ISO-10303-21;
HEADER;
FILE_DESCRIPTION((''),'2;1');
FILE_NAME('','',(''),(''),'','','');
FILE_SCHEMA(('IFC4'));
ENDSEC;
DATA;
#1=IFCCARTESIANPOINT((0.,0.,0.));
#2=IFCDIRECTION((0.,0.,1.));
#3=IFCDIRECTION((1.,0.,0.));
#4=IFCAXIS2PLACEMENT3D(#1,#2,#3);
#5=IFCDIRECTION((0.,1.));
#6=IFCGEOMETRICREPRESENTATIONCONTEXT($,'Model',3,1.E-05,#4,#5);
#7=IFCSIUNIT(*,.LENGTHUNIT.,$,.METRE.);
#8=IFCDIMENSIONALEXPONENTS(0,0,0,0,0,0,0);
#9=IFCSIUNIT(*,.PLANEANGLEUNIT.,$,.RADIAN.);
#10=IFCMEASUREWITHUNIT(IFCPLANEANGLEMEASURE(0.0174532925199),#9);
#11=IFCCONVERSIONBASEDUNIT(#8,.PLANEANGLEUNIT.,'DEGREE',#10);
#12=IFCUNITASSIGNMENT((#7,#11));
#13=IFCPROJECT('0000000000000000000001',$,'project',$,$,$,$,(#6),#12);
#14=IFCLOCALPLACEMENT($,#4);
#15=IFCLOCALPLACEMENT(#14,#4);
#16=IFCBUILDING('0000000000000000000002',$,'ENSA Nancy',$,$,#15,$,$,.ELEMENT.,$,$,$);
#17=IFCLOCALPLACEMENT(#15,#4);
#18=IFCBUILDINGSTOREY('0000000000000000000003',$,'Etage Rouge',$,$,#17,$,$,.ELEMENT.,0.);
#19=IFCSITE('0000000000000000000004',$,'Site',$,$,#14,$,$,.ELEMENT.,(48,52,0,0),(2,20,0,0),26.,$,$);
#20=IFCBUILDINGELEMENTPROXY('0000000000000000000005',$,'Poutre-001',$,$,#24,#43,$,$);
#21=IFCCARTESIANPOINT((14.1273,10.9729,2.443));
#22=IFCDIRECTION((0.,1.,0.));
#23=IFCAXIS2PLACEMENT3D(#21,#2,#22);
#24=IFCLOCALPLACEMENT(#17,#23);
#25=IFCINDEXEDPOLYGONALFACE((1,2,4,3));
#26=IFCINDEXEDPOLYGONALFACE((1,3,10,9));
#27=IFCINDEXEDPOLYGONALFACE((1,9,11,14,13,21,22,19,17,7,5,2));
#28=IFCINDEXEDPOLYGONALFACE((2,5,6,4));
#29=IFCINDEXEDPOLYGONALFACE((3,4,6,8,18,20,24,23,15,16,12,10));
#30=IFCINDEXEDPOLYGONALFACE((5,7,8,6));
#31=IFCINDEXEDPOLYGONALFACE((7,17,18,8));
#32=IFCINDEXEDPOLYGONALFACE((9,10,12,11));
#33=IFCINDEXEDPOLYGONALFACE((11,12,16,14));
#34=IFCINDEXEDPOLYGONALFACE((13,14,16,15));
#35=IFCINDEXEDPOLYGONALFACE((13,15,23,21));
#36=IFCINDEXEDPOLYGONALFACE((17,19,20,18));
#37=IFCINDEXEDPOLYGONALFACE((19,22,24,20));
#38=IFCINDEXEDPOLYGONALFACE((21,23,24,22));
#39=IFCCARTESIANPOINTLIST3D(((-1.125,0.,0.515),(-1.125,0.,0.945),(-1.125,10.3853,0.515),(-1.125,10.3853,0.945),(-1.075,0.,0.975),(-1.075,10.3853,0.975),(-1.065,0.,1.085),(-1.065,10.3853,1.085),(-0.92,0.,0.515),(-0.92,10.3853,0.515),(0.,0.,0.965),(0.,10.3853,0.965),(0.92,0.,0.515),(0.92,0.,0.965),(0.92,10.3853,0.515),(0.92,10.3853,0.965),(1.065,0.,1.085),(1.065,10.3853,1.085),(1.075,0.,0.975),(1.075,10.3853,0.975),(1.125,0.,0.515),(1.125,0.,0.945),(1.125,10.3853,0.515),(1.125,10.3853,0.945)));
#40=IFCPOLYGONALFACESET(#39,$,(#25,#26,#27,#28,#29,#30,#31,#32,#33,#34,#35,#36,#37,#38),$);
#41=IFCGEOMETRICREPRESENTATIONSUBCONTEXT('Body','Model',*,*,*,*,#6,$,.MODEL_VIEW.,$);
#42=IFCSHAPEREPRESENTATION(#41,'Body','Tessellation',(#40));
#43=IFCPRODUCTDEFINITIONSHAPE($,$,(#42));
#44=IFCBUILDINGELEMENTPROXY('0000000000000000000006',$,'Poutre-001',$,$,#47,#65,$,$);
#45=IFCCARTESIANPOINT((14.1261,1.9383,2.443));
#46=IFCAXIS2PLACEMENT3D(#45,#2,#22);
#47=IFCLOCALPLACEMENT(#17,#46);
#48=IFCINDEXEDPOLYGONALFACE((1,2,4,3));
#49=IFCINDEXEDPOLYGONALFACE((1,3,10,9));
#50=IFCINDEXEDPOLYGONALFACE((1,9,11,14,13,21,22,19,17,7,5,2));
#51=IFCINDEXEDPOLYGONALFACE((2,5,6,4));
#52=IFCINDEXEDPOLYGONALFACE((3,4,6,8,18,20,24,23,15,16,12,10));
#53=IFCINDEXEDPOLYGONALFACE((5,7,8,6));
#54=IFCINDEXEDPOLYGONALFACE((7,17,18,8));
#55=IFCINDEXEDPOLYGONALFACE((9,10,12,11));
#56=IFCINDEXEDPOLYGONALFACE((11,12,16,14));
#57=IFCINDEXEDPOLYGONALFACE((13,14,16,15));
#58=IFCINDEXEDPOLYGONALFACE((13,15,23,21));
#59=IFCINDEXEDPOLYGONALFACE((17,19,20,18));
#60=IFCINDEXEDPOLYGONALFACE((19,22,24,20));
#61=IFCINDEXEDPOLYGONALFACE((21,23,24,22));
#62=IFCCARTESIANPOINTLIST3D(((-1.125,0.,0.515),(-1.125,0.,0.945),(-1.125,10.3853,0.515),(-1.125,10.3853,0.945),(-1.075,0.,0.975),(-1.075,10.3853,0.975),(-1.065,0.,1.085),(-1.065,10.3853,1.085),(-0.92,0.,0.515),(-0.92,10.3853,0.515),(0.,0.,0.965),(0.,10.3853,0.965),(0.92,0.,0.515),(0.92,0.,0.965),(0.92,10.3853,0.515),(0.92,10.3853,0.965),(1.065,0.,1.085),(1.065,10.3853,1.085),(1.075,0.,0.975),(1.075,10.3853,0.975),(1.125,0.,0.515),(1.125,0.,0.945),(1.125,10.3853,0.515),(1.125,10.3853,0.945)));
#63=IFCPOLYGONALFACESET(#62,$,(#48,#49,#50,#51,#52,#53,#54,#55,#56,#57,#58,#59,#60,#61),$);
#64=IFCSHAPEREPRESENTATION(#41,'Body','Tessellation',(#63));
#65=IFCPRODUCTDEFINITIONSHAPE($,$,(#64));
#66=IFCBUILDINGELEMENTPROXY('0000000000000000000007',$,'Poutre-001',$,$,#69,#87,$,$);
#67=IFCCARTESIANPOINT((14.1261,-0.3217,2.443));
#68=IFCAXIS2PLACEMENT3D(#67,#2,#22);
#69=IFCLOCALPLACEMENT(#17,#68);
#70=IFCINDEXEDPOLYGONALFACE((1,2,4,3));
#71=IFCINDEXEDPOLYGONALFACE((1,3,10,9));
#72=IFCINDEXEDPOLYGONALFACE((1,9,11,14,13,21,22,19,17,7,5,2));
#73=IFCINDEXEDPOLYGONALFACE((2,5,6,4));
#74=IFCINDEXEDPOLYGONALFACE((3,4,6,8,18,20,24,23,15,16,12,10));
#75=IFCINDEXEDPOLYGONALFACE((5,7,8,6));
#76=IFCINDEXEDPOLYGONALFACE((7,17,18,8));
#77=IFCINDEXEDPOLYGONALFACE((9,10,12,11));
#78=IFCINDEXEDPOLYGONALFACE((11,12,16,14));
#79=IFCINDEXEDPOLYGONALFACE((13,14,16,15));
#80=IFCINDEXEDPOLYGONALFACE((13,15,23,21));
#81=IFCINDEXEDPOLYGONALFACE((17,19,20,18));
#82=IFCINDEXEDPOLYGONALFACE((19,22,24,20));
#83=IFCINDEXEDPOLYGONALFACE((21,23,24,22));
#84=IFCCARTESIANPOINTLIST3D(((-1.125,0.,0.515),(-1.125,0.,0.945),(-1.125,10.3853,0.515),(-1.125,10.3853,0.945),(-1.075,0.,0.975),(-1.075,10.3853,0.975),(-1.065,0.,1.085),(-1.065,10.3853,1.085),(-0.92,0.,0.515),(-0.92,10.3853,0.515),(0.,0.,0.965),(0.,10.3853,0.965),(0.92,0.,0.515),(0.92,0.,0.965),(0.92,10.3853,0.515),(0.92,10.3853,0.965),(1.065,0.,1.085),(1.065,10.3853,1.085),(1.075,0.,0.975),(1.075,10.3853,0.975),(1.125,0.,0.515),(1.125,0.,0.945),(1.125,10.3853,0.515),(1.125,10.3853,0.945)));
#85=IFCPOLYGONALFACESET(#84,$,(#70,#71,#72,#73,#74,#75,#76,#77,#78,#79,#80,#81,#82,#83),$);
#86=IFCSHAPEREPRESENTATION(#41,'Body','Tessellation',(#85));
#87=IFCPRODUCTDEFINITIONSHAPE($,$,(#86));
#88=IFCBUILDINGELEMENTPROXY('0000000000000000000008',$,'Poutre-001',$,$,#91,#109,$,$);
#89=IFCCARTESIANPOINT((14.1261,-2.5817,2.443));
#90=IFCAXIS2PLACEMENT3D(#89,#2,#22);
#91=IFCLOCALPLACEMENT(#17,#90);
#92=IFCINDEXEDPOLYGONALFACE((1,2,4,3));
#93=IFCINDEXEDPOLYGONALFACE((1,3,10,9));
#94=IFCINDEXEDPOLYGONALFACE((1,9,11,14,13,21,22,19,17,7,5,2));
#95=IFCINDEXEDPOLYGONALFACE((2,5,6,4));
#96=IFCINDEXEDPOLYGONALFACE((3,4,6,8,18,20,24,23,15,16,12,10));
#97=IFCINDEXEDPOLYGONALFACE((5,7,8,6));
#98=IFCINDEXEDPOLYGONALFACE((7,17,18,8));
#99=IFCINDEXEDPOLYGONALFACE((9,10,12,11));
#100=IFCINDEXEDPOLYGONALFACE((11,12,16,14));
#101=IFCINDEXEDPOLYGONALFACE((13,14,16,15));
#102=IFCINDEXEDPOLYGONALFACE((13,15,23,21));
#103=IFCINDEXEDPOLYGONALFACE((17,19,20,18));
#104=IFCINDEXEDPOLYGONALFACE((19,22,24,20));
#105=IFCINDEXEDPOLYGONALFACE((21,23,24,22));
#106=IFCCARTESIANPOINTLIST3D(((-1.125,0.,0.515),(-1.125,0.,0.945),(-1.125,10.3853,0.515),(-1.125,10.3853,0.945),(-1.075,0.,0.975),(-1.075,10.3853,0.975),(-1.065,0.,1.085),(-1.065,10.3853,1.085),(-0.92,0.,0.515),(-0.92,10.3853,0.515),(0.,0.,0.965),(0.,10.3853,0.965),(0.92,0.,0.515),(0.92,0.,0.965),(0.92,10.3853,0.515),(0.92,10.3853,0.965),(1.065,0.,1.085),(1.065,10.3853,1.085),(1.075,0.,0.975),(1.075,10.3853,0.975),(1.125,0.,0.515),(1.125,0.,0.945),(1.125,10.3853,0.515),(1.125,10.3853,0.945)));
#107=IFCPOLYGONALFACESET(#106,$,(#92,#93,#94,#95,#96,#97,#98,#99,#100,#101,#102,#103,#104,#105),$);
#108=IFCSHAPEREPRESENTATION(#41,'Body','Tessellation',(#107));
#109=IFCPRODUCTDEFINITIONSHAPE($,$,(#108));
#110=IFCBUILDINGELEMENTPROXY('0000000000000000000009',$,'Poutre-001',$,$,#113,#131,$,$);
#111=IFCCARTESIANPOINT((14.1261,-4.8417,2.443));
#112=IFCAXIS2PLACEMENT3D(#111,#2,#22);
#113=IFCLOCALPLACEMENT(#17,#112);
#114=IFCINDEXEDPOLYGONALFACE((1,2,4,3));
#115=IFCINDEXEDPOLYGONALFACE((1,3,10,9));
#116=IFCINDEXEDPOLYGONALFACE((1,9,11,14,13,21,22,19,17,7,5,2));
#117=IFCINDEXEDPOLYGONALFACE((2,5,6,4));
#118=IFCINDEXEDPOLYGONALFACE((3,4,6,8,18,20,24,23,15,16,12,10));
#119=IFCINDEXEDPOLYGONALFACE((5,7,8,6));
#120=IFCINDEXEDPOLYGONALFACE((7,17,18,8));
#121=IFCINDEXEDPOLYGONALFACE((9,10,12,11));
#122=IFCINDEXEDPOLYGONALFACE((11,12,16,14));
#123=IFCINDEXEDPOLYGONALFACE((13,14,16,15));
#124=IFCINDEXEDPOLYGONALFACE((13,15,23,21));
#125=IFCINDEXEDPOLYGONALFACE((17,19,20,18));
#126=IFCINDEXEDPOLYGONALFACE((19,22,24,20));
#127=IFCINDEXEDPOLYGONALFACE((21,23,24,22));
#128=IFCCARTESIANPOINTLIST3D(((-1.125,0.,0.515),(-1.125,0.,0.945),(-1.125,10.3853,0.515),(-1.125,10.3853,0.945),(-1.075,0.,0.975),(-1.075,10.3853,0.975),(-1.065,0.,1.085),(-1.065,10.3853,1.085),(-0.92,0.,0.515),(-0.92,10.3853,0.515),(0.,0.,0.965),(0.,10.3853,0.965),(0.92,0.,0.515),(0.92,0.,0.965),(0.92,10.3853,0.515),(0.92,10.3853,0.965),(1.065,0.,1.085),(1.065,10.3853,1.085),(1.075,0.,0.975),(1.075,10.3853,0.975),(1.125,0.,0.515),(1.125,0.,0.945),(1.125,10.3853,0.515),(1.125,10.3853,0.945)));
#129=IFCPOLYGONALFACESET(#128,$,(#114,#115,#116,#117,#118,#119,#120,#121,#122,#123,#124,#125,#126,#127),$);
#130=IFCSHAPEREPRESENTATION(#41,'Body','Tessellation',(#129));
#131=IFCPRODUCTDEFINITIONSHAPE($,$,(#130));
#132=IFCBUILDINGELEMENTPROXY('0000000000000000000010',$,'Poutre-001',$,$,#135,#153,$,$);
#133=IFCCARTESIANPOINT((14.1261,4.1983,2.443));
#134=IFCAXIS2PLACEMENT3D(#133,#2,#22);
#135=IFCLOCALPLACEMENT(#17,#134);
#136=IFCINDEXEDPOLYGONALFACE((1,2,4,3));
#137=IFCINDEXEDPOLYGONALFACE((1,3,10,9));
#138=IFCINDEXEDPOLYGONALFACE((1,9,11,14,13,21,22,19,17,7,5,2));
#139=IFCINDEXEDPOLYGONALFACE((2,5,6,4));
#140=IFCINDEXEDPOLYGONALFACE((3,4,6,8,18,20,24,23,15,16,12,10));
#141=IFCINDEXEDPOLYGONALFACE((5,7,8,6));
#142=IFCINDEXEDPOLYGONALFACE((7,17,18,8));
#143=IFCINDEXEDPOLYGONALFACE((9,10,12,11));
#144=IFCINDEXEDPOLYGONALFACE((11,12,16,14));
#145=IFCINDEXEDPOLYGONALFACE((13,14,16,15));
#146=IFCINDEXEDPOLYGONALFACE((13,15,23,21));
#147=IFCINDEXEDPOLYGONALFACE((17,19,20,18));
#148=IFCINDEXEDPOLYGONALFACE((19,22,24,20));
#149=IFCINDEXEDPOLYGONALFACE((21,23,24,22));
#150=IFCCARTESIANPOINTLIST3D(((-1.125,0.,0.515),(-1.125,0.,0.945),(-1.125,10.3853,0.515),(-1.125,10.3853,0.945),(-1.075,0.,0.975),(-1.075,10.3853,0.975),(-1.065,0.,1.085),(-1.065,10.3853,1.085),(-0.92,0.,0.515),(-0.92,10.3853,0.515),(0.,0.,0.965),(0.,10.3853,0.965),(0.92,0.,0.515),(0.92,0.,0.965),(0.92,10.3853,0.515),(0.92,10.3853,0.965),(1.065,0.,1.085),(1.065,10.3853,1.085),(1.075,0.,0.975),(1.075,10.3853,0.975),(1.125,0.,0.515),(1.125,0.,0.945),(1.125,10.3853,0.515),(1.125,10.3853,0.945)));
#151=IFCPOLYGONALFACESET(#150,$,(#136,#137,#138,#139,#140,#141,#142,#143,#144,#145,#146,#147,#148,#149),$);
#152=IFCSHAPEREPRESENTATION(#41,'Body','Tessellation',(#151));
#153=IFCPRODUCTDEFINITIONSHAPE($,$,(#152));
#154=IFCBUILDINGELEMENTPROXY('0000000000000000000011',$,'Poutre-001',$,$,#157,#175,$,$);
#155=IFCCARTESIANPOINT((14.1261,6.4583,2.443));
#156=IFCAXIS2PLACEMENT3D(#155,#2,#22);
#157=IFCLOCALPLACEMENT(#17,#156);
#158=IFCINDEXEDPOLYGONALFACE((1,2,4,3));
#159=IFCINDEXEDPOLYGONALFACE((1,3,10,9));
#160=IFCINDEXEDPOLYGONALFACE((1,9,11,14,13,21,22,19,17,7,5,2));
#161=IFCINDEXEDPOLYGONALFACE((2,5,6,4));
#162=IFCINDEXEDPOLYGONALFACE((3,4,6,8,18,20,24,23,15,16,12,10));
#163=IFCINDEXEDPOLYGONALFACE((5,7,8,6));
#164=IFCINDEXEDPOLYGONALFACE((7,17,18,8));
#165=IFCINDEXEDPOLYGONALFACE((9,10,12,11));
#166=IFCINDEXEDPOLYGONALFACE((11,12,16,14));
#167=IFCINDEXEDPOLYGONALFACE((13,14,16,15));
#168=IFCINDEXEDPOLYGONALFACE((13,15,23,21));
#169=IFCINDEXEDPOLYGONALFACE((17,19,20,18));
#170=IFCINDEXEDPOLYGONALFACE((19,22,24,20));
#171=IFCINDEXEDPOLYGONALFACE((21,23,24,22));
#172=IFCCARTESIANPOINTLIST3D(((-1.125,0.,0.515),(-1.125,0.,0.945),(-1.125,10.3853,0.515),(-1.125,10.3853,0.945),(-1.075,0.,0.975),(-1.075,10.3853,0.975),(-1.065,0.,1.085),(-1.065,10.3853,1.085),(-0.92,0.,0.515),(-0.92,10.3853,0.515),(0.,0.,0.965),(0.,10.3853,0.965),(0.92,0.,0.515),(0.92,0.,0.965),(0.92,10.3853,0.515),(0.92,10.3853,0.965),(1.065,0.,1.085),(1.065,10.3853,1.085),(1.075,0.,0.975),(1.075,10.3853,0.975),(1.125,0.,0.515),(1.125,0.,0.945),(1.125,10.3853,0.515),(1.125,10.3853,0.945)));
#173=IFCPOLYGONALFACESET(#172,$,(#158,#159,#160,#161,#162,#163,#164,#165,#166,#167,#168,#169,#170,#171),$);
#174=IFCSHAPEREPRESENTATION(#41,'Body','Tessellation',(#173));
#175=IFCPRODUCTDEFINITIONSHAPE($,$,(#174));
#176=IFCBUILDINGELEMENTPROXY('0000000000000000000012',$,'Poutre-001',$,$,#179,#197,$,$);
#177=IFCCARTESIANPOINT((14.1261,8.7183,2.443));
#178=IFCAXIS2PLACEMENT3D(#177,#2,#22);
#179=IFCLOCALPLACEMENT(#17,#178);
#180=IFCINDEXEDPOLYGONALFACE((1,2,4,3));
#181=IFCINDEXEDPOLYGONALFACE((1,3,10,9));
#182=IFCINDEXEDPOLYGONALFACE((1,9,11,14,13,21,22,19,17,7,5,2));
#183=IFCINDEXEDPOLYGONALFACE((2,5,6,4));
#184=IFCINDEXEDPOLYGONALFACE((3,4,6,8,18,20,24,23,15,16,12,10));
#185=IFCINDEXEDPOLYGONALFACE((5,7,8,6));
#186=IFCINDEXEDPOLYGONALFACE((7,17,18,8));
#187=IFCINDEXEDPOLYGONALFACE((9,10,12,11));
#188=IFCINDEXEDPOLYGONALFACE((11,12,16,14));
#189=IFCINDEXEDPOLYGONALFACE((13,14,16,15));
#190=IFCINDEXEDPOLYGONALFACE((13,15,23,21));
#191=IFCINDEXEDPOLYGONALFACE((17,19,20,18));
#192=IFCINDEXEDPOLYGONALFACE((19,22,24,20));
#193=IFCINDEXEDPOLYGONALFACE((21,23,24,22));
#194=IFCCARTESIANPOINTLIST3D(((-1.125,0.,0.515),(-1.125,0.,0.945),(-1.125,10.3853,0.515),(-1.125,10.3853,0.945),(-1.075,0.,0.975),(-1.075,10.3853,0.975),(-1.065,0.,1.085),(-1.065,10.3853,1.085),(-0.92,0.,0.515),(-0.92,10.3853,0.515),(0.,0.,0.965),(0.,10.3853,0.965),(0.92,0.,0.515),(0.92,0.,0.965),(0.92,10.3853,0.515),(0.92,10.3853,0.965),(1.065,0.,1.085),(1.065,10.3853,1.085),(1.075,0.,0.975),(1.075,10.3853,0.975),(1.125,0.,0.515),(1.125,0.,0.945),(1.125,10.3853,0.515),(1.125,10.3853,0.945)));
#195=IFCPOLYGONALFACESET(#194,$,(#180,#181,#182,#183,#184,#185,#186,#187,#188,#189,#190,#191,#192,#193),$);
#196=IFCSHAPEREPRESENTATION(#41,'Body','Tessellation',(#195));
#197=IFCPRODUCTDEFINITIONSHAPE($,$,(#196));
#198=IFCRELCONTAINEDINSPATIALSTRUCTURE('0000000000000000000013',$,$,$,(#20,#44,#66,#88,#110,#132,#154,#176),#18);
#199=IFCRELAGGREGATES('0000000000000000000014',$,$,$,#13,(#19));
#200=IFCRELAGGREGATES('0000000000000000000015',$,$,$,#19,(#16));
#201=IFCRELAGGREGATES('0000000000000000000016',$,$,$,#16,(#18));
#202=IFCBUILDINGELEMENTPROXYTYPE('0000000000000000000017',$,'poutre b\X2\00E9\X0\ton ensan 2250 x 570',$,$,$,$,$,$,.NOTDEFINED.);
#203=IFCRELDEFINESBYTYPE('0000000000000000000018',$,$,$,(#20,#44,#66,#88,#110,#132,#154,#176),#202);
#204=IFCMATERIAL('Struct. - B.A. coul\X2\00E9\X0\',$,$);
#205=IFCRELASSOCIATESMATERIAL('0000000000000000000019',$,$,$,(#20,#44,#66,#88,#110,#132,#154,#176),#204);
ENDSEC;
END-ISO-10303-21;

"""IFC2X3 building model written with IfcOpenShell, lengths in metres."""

from ifc_helpers import new_model, entity, si_unit, converted_unit, direction, frame, origin_with_axes, place, context, subcontext, project, spatial, polyline, outline, extrude, material, type_object, element, save


model = new_model("IFC2X3")

# Units and contexts
model_context = context("Model", 3, precision=1e-05, world=origin_with_axes(), true_north=direction((0.0, 1.0)))
body_context = subcontext(model_context, "Body", "Model", "MODEL_VIEW")
ifc_project = project(units=[si_unit("LENGTHUNIT", "METRE"), converted_unit("PLANEANGLEUNIT", "DEGREE", entity("IfcPlaneAngleMeasure", 0.0174532925199), si_unit("PLANEANGLEUNIT", "RADIAN"), dimensions=[0, 0, 0, 0, 0, 0, 0])], contexts=[model_context])

# Site, building, storey
site_placement = place(None, origin_with_axes())
site = spatial("IfcSite", under=ifc_project, at=site_placement, Name="Site", CompositionType="ELEMENT", RefLatitude=(48, 52, 0, 0), RefLongitude=(2, 20, 0, 0), RefElevation=26.0)
building_placement = place(site_placement, origin_with_axes())
building = spatial("IfcBuilding", under=site, at=building_placement, Name="ENSA Nancy", CompositionType="ELEMENT")
storey_placement = place(building_placement, origin_with_axes())
storey = spatial("IfcBuildingStorey", under=building, at=storey_placement, Name="Etage Rouge", CompositionType="ELEMENT", Elevation=0.0)

# Building element proxies
ifc_material_1 = material(Name="Struct. - B.A. coulé")
building_element_proxy_type_1 = type_object("IfcBuildingElementProxyType", Name="poutre béton ensan 2250 x 570", PredefinedType="NOTDEFINED")
for number, where, z_axis, x_axis, name in (
    (1, (14.1273, 10.9729, 2.443), (0.0, 0.0, 1.0), (0.0, 1.0, 0.0), "Poutre-001"),
    (2, (14.1261, 1.9383, 2.443), (0.0, 0.0, 1.0), (0.0, 1.0, 0.0), "Poutre-001"),
    (3, (14.1261, -0.3217, 2.443), (0.0, 0.0, 1.0), (0.0, 1.0, 0.0), "Poutre-001"),
    (4, (14.1261, -2.5817, 2.443), (0.0, 0.0, 1.0), (0.0, 1.0, 0.0), "Poutre-001"),
    (5, (14.1261, -4.8417, 2.443), (0.0, 0.0, 1.0), (0.0, 1.0, 0.0), "Poutre-001"),
    (6, (14.1261, 4.1983, 2.443), (0.0, 0.0, 1.0), (0.0, 1.0, 0.0), "Poutre-001"),
    (7, (14.1261, 6.4583, 2.443), (0.0, 0.0, 1.0), (0.0, 1.0, 0.0), "Poutre-001"),
    (8, (14.1261, 8.7183, 2.443), (0.0, 0.0, 1.0), (0.0, 1.0, 0.0), "Poutre-001"),
):
    element("IfcBuildingElementProxy", number, at=place(storey_placement, frame(where, z_axis=z_axis, x_axis=x_axis)), inside=storey, type_object=building_element_proxy_type_1, material=ifc_material_1, Name=name, context=body_context, shape_type="SweptSolid", body=[
        extrude(outline(polyline([(-1.065, 1.085), (-1.075, 0.975), (-1.125, 0.945), (-1.125, 0.515), (-0.92, 0.515), (0.0, 0.965), (0.92, 0.965), (0.92, 0.515), (1.125, 0.515), (1.125, 0.945), (1.075, 0.975), (1.065, 1.085), (-1.065, 1.085)])), frame((0.0, 10.3853, 0.0), z_axis=(0.0, -1.0, 0.0), x_axis=(1.0, 0.0, 0.0)), (0.0, 0.0, 1.0), 10.3853),
    ])

save(model, "model.ifc")
